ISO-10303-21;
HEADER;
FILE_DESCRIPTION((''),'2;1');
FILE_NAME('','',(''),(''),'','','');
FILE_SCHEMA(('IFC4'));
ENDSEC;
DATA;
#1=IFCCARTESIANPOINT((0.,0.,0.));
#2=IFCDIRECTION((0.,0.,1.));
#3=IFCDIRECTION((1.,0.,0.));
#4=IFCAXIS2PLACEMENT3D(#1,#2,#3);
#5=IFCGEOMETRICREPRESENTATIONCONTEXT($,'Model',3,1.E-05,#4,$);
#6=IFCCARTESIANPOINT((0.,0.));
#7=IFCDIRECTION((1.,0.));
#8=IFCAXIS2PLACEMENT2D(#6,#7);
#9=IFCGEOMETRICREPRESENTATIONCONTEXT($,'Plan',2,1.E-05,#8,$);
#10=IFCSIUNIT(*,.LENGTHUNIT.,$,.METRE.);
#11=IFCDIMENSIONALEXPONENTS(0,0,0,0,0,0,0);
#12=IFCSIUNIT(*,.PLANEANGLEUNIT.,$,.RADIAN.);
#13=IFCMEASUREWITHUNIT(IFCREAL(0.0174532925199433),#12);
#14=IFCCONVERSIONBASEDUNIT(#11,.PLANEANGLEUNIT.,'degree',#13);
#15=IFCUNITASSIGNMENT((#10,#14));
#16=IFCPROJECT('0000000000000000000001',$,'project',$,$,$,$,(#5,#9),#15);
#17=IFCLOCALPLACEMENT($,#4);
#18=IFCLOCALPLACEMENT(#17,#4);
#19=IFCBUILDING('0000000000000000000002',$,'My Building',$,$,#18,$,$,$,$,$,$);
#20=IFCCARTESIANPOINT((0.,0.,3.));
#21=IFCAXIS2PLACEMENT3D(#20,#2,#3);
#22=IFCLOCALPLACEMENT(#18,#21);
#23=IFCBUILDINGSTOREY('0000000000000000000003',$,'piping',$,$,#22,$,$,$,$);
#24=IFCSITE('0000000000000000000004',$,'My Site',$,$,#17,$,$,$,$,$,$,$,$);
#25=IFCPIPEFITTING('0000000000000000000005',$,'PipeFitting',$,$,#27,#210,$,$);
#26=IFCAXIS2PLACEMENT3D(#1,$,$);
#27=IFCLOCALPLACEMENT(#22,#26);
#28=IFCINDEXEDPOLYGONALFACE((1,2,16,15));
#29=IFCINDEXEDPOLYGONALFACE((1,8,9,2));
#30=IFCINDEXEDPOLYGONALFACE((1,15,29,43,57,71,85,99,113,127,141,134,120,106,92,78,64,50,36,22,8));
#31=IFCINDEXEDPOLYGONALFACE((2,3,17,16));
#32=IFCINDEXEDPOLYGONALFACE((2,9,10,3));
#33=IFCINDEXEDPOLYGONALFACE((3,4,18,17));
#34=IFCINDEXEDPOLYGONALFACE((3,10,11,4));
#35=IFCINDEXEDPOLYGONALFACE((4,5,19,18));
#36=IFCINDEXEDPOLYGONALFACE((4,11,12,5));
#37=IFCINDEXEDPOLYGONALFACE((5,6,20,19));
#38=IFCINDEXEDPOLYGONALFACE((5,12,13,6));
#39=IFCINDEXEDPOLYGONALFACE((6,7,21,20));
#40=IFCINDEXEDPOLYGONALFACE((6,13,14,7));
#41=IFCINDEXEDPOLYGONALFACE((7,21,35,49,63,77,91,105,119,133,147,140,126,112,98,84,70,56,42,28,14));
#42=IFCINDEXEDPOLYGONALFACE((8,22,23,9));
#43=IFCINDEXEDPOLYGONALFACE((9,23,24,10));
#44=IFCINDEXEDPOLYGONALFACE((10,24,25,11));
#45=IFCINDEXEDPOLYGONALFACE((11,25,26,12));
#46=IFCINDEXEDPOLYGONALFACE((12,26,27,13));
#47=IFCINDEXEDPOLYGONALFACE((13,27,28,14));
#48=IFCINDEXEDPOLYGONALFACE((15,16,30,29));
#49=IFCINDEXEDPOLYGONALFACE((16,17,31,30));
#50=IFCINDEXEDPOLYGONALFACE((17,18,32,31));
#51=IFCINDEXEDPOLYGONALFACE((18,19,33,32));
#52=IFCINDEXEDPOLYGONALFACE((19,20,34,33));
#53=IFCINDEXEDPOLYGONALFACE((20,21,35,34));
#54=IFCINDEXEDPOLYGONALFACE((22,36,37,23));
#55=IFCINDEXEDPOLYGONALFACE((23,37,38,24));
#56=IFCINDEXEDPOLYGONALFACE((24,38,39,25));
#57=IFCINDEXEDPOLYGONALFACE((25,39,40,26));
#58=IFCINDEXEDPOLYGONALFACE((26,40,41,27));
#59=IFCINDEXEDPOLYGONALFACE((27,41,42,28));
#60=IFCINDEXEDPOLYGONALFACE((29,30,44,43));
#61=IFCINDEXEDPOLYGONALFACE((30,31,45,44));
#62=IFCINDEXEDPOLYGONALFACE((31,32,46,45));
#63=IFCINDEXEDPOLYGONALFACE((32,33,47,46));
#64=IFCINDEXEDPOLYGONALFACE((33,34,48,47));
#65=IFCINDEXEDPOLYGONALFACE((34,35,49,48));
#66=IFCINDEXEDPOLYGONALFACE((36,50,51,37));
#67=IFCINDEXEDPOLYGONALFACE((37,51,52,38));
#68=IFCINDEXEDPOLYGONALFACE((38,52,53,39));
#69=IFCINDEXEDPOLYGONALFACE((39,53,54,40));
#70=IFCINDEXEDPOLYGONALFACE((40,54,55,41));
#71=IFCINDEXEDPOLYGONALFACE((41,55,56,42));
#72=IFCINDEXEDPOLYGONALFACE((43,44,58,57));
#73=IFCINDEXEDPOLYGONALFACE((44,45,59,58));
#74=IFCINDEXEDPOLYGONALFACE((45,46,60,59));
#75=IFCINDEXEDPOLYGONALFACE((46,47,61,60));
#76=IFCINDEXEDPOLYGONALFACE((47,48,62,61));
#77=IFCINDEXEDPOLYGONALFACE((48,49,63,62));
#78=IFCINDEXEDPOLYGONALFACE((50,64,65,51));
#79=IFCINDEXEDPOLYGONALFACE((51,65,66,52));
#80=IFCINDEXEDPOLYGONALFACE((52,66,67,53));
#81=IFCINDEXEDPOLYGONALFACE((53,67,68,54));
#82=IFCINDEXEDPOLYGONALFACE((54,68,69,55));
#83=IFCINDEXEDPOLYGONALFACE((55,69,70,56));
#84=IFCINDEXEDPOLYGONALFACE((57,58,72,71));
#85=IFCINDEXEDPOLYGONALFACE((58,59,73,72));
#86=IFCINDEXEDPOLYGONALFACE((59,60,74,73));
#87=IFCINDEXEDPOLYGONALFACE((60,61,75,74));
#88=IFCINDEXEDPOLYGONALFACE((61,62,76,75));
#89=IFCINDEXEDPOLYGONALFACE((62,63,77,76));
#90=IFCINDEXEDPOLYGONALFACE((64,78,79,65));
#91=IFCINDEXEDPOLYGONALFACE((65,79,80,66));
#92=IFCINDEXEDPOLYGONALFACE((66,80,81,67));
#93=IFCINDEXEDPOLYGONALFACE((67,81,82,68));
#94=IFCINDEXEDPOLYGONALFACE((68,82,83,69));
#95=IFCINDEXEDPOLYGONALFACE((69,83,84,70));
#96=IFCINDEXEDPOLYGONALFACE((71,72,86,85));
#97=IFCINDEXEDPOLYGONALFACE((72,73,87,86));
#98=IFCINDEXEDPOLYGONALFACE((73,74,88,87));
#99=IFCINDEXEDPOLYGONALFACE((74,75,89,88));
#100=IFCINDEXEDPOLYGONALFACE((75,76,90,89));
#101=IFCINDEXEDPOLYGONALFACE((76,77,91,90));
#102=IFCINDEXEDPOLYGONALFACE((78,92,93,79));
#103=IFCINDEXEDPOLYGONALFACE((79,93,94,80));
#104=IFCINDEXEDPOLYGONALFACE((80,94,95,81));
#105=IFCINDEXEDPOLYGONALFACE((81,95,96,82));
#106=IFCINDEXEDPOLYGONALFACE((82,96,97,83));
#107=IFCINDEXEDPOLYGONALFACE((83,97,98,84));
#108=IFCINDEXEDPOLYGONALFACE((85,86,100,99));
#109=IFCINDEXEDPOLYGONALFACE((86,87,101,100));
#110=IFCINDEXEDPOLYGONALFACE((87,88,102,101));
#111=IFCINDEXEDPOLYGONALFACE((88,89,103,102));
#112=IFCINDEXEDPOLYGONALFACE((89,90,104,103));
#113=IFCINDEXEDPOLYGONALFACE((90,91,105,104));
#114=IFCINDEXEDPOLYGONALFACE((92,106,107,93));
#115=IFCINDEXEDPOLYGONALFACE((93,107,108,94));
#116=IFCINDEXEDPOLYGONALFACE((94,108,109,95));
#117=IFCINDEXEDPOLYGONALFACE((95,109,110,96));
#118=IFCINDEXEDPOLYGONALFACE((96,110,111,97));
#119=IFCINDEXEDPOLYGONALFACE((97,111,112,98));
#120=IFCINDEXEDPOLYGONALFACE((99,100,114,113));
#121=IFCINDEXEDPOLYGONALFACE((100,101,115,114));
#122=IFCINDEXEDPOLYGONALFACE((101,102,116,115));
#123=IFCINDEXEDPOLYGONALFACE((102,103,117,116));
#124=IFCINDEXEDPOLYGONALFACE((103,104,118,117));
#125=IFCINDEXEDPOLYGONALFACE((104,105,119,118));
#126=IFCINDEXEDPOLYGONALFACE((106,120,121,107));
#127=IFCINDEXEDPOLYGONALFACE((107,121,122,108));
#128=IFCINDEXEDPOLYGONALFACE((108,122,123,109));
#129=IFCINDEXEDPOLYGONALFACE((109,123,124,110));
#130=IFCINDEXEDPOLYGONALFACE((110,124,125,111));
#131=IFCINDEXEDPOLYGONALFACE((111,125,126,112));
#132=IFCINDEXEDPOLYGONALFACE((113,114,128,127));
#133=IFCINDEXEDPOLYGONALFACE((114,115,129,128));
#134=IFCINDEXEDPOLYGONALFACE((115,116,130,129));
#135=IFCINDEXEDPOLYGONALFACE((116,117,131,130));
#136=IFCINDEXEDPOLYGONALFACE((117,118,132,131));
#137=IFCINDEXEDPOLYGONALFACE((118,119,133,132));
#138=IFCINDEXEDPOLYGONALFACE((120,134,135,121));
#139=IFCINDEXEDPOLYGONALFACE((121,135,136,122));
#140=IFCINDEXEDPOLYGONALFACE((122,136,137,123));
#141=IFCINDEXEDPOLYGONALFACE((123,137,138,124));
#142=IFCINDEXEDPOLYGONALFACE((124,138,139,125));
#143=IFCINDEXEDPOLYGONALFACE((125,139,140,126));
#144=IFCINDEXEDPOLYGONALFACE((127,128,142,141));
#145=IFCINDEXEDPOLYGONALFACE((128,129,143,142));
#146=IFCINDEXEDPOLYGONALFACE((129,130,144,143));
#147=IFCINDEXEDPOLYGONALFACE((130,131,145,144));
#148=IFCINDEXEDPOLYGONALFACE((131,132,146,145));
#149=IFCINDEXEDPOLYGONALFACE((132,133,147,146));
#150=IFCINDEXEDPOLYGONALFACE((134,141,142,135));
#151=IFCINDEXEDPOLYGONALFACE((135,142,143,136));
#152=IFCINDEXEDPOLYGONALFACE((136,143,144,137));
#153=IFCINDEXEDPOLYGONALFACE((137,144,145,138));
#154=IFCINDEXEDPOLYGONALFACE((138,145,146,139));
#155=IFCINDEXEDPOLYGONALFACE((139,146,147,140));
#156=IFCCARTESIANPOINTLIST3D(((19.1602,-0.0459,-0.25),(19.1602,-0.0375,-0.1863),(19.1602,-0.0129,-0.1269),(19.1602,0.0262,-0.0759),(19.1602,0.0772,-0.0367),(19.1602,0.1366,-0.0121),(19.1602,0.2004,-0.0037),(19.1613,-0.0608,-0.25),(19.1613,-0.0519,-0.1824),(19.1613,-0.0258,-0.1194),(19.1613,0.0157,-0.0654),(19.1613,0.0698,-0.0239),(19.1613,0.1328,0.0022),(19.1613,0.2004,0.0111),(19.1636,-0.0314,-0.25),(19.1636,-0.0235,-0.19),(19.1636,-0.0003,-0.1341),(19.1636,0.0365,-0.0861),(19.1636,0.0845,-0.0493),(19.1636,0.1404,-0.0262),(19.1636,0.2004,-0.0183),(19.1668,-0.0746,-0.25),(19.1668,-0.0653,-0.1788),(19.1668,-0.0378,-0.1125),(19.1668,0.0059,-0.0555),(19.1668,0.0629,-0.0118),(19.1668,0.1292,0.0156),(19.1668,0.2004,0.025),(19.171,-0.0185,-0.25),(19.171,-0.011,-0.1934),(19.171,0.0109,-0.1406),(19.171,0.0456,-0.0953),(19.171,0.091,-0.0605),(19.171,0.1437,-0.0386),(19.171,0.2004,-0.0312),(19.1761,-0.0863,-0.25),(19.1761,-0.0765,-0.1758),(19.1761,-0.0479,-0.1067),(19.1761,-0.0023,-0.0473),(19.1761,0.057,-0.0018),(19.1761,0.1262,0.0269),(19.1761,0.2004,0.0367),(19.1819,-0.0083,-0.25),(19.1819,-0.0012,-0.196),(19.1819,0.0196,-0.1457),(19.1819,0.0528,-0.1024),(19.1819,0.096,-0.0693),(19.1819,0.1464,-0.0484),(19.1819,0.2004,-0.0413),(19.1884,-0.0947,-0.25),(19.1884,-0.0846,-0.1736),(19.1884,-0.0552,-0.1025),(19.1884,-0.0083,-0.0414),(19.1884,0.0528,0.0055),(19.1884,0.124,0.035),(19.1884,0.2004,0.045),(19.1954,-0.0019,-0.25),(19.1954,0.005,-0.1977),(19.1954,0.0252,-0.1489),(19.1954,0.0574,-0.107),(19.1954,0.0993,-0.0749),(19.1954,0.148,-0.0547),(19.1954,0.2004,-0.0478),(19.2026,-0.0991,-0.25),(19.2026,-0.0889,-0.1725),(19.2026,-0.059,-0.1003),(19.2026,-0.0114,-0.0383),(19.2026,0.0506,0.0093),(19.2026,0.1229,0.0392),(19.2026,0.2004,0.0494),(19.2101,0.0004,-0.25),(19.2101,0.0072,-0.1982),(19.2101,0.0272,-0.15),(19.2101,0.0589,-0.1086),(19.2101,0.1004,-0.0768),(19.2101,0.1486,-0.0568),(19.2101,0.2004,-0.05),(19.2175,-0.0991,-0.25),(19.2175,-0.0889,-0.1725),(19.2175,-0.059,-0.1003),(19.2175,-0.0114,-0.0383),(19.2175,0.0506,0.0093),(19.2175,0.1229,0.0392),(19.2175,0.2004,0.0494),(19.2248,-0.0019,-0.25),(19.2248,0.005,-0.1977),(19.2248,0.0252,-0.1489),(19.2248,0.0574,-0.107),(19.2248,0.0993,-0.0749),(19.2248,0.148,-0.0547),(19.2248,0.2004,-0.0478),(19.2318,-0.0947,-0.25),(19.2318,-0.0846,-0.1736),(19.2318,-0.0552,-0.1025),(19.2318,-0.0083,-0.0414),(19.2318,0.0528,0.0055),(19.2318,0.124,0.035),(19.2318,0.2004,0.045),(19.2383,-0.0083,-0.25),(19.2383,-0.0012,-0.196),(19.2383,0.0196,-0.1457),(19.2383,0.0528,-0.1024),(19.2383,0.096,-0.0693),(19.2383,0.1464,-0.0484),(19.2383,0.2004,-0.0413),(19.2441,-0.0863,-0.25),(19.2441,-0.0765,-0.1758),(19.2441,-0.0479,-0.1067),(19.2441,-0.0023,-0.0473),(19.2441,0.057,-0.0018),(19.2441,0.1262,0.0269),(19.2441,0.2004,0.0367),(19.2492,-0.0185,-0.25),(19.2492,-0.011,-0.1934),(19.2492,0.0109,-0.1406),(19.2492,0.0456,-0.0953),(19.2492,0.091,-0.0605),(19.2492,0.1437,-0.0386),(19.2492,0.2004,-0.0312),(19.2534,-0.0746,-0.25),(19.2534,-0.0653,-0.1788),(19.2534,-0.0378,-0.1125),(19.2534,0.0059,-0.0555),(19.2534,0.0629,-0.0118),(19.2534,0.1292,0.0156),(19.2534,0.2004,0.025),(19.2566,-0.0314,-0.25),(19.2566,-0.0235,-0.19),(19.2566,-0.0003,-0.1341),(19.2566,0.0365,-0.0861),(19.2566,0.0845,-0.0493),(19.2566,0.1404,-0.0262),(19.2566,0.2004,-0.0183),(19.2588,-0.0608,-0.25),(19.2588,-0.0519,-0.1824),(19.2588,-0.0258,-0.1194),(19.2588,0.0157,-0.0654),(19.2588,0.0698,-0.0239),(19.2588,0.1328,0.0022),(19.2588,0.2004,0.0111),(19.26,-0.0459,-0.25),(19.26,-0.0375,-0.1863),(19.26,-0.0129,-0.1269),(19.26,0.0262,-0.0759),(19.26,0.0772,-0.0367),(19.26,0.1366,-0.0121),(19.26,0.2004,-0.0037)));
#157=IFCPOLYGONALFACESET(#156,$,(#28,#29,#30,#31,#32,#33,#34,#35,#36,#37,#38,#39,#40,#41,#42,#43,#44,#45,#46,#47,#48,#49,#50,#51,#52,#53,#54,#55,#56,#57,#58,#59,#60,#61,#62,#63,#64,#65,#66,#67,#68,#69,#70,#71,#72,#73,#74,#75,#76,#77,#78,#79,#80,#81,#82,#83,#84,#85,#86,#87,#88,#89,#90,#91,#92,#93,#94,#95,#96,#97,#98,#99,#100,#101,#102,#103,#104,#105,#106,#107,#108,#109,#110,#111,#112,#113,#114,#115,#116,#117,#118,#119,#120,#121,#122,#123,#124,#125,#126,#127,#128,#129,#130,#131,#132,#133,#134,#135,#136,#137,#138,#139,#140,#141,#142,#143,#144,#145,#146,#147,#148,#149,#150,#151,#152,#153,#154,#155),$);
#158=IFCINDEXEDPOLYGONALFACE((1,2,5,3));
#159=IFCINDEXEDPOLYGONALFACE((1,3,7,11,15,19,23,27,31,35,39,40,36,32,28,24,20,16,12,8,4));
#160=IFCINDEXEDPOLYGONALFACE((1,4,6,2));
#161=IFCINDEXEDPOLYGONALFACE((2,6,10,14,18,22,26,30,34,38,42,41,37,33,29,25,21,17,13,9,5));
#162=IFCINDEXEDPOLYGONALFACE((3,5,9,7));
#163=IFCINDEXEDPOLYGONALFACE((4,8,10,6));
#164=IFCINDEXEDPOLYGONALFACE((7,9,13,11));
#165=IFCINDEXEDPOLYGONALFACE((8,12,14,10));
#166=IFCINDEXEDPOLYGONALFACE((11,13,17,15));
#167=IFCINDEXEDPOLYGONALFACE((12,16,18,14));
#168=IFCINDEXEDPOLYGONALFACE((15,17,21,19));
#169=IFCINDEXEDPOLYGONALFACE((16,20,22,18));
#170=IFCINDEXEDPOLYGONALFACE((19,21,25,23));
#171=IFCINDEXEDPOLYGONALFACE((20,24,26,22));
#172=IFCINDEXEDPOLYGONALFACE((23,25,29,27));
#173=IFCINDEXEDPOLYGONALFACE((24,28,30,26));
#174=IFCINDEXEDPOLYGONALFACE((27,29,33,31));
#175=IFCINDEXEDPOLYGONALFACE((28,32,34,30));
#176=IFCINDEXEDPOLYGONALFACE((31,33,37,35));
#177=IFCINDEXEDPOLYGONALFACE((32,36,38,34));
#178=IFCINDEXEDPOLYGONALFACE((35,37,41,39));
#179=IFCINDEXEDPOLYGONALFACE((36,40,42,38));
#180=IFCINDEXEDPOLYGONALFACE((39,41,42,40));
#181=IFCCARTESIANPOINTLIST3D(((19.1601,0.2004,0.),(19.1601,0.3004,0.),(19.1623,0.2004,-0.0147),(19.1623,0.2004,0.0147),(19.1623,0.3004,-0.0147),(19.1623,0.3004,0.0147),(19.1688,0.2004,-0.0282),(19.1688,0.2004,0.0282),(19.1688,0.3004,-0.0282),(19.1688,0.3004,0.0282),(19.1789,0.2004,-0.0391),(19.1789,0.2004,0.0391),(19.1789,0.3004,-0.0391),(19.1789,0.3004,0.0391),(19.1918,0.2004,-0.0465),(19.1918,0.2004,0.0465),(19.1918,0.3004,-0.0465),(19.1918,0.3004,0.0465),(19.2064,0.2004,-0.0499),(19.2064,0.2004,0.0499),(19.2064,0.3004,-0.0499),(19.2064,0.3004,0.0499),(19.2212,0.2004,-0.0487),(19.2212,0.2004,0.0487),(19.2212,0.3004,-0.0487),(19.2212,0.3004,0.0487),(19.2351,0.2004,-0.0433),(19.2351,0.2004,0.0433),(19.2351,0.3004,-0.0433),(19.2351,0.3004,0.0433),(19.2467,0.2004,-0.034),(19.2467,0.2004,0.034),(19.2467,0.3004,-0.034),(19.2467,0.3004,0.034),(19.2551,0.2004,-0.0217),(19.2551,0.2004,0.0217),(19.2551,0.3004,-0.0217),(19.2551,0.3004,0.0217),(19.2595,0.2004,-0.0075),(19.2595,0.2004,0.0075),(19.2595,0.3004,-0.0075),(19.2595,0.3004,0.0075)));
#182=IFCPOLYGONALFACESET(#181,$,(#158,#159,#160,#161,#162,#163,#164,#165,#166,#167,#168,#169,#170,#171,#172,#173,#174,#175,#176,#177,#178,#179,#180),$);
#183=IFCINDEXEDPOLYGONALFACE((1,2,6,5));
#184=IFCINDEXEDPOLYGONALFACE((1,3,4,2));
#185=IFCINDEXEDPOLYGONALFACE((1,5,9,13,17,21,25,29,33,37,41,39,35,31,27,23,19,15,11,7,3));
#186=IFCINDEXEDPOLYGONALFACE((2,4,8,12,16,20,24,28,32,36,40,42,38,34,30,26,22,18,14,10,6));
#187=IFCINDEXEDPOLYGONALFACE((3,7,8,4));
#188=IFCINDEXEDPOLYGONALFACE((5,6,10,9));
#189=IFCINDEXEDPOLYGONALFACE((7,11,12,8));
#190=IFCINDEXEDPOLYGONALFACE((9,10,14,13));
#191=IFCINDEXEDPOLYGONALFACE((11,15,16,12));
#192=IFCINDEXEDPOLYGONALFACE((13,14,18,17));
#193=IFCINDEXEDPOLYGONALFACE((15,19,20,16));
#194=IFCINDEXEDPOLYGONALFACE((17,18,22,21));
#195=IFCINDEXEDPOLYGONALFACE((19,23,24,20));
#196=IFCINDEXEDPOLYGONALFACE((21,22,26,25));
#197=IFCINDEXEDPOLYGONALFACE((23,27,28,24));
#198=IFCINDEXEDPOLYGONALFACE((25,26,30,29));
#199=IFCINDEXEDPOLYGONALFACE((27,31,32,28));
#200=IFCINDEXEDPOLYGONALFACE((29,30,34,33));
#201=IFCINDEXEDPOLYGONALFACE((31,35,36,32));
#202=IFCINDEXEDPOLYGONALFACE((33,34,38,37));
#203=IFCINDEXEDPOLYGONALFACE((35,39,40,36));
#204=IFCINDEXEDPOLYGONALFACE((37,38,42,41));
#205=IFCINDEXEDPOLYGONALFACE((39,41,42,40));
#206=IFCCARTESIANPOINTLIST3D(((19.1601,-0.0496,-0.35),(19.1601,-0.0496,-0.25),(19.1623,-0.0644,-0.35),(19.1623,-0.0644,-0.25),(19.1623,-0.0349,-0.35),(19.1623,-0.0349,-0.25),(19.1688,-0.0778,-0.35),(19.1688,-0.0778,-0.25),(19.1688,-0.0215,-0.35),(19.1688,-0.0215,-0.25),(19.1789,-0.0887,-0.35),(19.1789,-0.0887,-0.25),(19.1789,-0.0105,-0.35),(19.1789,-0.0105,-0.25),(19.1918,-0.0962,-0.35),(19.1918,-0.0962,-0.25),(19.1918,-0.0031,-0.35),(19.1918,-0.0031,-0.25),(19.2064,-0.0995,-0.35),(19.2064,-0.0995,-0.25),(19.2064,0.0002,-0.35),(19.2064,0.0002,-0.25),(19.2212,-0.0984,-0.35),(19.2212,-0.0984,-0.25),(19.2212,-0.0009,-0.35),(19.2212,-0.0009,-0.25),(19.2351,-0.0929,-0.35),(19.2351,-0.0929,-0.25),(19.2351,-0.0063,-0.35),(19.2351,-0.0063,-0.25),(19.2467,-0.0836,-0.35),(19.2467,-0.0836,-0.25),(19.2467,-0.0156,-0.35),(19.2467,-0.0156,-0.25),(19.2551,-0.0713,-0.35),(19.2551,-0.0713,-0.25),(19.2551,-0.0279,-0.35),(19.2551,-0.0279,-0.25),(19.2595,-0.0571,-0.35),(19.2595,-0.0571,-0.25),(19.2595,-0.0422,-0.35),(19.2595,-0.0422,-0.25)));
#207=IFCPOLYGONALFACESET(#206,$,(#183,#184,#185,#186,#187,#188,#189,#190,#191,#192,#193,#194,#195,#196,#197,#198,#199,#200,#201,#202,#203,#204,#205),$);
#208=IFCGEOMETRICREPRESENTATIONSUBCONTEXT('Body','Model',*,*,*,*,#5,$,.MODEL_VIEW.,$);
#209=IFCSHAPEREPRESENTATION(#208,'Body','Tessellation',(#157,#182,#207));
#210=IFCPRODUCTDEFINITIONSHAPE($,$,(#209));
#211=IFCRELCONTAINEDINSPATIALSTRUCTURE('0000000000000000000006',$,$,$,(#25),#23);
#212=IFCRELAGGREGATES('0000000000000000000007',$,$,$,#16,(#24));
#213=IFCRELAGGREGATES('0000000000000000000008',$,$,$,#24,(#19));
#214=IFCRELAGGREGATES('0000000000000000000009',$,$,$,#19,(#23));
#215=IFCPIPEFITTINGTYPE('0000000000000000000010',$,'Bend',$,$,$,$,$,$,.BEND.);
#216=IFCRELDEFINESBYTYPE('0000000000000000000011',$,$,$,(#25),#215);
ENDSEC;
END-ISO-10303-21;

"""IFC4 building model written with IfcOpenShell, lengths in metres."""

from ifc_helpers import new_model, entity, si_unit, converted_unit, frame, origin_with_axes, origin_2d_with_axis, place, context, subcontext, project, spatial, circle, extrude, source, transform, mapped, type_object, type_shapes, element, save


model = new_model("IFC4")

# Units and contexts
model_context = context("Model", 3, precision=1e-05, world=origin_with_axes())
plan_context = context("Plan", 2, precision=1e-05, world=origin_2d_with_axis())
body_context = subcontext(model_context, "Body", "Model", "MODEL_VIEW")
ifc_project = project(units=[si_unit("LENGTHUNIT", "METRE"), converted_unit("PLANEANGLEUNIT", "degree", entity("IfcReal", 0.0174532925199433), si_unit("PLANEANGLEUNIT", "RADIAN"), dimensions=[0, 0, 0, 0, 0, 0, 0])], contexts=[model_context, plan_context])

# Site, building, storey
site_placement = place(None, origin_with_axes())
site = spatial("IfcSite", under=ifc_project, at=site_placement, Name="My Site")
building_placement = place(site_placement, origin_with_axes())
building = spatial("IfcBuilding", under=site, at=building_placement, Name="My Building")
storey_placement = place(building_placement, frame((0.0, 0.0, 3.0), z_axis=(0.0, 0.0, 1.0), x_axis=(1.0, 0.0, 0.0)))
storey = spatial("IfcBuildingStorey", under=building, at=storey_placement, Name="piping")

# Pipe fitting
pipe_fitting_type = type_object("IfcPipeFittingType", Name="Bend", PredefinedType="BEND")
shared_shape = source(origin_with_axes(), body_context, "Body", "SolidModel", [
    entity("IfcSweptDiskSolid", entity("IfcIndexedPolyCurve", entity("IfcCartesianPointList3D", [[0.0, 0.0, -0.1], [0.0, -0.0732, -0.2768], [0.0, -0.25, -0.35]]), [entity("IfcArcIndex", [1, 2, 3])]), 0.05),
    extrude(circle(Radius=0.05), origin_with_axes(), (0.0, 0.0, -1.0), 0.1),
    extrude(circle(Radius=0.05), frame((0.0, -0.25, -0.35), z_axis=(0.0, -1.0, 0.0), x_axis=(1.0, 0.0, 0.0)), (0.0, 0.0, 1.0), 0.1),
])
type_shapes(pipe_fitting_type, [shared_shape])
for number, where, z_axis, x_axis, name in (
    (1, (19.2101, 0.3004, 0.0), (0.0, 1.0, 0.0), (-1.0, 0.0, 0.0), "PipeFitting"),
):
    element("IfcPipeFitting", number, at=place(storey_placement, frame(where, z_axis=z_axis, x_axis=x_axis)), inside=storey, type_object=pipe_fitting_type, Name=name, context=body_context, shape_type="MappedRepresentation", body=[
        mapped(shared_shape, transform((0.0, 0.0, 0.0), x_axis=(1.0, 0.0, 0.0), y_axis=(0.0, 1.0, 0.0), z_axis=(0.0, 0.0, 1.0), scale=1.0)),
    ])

save(model, "model.ifc")
